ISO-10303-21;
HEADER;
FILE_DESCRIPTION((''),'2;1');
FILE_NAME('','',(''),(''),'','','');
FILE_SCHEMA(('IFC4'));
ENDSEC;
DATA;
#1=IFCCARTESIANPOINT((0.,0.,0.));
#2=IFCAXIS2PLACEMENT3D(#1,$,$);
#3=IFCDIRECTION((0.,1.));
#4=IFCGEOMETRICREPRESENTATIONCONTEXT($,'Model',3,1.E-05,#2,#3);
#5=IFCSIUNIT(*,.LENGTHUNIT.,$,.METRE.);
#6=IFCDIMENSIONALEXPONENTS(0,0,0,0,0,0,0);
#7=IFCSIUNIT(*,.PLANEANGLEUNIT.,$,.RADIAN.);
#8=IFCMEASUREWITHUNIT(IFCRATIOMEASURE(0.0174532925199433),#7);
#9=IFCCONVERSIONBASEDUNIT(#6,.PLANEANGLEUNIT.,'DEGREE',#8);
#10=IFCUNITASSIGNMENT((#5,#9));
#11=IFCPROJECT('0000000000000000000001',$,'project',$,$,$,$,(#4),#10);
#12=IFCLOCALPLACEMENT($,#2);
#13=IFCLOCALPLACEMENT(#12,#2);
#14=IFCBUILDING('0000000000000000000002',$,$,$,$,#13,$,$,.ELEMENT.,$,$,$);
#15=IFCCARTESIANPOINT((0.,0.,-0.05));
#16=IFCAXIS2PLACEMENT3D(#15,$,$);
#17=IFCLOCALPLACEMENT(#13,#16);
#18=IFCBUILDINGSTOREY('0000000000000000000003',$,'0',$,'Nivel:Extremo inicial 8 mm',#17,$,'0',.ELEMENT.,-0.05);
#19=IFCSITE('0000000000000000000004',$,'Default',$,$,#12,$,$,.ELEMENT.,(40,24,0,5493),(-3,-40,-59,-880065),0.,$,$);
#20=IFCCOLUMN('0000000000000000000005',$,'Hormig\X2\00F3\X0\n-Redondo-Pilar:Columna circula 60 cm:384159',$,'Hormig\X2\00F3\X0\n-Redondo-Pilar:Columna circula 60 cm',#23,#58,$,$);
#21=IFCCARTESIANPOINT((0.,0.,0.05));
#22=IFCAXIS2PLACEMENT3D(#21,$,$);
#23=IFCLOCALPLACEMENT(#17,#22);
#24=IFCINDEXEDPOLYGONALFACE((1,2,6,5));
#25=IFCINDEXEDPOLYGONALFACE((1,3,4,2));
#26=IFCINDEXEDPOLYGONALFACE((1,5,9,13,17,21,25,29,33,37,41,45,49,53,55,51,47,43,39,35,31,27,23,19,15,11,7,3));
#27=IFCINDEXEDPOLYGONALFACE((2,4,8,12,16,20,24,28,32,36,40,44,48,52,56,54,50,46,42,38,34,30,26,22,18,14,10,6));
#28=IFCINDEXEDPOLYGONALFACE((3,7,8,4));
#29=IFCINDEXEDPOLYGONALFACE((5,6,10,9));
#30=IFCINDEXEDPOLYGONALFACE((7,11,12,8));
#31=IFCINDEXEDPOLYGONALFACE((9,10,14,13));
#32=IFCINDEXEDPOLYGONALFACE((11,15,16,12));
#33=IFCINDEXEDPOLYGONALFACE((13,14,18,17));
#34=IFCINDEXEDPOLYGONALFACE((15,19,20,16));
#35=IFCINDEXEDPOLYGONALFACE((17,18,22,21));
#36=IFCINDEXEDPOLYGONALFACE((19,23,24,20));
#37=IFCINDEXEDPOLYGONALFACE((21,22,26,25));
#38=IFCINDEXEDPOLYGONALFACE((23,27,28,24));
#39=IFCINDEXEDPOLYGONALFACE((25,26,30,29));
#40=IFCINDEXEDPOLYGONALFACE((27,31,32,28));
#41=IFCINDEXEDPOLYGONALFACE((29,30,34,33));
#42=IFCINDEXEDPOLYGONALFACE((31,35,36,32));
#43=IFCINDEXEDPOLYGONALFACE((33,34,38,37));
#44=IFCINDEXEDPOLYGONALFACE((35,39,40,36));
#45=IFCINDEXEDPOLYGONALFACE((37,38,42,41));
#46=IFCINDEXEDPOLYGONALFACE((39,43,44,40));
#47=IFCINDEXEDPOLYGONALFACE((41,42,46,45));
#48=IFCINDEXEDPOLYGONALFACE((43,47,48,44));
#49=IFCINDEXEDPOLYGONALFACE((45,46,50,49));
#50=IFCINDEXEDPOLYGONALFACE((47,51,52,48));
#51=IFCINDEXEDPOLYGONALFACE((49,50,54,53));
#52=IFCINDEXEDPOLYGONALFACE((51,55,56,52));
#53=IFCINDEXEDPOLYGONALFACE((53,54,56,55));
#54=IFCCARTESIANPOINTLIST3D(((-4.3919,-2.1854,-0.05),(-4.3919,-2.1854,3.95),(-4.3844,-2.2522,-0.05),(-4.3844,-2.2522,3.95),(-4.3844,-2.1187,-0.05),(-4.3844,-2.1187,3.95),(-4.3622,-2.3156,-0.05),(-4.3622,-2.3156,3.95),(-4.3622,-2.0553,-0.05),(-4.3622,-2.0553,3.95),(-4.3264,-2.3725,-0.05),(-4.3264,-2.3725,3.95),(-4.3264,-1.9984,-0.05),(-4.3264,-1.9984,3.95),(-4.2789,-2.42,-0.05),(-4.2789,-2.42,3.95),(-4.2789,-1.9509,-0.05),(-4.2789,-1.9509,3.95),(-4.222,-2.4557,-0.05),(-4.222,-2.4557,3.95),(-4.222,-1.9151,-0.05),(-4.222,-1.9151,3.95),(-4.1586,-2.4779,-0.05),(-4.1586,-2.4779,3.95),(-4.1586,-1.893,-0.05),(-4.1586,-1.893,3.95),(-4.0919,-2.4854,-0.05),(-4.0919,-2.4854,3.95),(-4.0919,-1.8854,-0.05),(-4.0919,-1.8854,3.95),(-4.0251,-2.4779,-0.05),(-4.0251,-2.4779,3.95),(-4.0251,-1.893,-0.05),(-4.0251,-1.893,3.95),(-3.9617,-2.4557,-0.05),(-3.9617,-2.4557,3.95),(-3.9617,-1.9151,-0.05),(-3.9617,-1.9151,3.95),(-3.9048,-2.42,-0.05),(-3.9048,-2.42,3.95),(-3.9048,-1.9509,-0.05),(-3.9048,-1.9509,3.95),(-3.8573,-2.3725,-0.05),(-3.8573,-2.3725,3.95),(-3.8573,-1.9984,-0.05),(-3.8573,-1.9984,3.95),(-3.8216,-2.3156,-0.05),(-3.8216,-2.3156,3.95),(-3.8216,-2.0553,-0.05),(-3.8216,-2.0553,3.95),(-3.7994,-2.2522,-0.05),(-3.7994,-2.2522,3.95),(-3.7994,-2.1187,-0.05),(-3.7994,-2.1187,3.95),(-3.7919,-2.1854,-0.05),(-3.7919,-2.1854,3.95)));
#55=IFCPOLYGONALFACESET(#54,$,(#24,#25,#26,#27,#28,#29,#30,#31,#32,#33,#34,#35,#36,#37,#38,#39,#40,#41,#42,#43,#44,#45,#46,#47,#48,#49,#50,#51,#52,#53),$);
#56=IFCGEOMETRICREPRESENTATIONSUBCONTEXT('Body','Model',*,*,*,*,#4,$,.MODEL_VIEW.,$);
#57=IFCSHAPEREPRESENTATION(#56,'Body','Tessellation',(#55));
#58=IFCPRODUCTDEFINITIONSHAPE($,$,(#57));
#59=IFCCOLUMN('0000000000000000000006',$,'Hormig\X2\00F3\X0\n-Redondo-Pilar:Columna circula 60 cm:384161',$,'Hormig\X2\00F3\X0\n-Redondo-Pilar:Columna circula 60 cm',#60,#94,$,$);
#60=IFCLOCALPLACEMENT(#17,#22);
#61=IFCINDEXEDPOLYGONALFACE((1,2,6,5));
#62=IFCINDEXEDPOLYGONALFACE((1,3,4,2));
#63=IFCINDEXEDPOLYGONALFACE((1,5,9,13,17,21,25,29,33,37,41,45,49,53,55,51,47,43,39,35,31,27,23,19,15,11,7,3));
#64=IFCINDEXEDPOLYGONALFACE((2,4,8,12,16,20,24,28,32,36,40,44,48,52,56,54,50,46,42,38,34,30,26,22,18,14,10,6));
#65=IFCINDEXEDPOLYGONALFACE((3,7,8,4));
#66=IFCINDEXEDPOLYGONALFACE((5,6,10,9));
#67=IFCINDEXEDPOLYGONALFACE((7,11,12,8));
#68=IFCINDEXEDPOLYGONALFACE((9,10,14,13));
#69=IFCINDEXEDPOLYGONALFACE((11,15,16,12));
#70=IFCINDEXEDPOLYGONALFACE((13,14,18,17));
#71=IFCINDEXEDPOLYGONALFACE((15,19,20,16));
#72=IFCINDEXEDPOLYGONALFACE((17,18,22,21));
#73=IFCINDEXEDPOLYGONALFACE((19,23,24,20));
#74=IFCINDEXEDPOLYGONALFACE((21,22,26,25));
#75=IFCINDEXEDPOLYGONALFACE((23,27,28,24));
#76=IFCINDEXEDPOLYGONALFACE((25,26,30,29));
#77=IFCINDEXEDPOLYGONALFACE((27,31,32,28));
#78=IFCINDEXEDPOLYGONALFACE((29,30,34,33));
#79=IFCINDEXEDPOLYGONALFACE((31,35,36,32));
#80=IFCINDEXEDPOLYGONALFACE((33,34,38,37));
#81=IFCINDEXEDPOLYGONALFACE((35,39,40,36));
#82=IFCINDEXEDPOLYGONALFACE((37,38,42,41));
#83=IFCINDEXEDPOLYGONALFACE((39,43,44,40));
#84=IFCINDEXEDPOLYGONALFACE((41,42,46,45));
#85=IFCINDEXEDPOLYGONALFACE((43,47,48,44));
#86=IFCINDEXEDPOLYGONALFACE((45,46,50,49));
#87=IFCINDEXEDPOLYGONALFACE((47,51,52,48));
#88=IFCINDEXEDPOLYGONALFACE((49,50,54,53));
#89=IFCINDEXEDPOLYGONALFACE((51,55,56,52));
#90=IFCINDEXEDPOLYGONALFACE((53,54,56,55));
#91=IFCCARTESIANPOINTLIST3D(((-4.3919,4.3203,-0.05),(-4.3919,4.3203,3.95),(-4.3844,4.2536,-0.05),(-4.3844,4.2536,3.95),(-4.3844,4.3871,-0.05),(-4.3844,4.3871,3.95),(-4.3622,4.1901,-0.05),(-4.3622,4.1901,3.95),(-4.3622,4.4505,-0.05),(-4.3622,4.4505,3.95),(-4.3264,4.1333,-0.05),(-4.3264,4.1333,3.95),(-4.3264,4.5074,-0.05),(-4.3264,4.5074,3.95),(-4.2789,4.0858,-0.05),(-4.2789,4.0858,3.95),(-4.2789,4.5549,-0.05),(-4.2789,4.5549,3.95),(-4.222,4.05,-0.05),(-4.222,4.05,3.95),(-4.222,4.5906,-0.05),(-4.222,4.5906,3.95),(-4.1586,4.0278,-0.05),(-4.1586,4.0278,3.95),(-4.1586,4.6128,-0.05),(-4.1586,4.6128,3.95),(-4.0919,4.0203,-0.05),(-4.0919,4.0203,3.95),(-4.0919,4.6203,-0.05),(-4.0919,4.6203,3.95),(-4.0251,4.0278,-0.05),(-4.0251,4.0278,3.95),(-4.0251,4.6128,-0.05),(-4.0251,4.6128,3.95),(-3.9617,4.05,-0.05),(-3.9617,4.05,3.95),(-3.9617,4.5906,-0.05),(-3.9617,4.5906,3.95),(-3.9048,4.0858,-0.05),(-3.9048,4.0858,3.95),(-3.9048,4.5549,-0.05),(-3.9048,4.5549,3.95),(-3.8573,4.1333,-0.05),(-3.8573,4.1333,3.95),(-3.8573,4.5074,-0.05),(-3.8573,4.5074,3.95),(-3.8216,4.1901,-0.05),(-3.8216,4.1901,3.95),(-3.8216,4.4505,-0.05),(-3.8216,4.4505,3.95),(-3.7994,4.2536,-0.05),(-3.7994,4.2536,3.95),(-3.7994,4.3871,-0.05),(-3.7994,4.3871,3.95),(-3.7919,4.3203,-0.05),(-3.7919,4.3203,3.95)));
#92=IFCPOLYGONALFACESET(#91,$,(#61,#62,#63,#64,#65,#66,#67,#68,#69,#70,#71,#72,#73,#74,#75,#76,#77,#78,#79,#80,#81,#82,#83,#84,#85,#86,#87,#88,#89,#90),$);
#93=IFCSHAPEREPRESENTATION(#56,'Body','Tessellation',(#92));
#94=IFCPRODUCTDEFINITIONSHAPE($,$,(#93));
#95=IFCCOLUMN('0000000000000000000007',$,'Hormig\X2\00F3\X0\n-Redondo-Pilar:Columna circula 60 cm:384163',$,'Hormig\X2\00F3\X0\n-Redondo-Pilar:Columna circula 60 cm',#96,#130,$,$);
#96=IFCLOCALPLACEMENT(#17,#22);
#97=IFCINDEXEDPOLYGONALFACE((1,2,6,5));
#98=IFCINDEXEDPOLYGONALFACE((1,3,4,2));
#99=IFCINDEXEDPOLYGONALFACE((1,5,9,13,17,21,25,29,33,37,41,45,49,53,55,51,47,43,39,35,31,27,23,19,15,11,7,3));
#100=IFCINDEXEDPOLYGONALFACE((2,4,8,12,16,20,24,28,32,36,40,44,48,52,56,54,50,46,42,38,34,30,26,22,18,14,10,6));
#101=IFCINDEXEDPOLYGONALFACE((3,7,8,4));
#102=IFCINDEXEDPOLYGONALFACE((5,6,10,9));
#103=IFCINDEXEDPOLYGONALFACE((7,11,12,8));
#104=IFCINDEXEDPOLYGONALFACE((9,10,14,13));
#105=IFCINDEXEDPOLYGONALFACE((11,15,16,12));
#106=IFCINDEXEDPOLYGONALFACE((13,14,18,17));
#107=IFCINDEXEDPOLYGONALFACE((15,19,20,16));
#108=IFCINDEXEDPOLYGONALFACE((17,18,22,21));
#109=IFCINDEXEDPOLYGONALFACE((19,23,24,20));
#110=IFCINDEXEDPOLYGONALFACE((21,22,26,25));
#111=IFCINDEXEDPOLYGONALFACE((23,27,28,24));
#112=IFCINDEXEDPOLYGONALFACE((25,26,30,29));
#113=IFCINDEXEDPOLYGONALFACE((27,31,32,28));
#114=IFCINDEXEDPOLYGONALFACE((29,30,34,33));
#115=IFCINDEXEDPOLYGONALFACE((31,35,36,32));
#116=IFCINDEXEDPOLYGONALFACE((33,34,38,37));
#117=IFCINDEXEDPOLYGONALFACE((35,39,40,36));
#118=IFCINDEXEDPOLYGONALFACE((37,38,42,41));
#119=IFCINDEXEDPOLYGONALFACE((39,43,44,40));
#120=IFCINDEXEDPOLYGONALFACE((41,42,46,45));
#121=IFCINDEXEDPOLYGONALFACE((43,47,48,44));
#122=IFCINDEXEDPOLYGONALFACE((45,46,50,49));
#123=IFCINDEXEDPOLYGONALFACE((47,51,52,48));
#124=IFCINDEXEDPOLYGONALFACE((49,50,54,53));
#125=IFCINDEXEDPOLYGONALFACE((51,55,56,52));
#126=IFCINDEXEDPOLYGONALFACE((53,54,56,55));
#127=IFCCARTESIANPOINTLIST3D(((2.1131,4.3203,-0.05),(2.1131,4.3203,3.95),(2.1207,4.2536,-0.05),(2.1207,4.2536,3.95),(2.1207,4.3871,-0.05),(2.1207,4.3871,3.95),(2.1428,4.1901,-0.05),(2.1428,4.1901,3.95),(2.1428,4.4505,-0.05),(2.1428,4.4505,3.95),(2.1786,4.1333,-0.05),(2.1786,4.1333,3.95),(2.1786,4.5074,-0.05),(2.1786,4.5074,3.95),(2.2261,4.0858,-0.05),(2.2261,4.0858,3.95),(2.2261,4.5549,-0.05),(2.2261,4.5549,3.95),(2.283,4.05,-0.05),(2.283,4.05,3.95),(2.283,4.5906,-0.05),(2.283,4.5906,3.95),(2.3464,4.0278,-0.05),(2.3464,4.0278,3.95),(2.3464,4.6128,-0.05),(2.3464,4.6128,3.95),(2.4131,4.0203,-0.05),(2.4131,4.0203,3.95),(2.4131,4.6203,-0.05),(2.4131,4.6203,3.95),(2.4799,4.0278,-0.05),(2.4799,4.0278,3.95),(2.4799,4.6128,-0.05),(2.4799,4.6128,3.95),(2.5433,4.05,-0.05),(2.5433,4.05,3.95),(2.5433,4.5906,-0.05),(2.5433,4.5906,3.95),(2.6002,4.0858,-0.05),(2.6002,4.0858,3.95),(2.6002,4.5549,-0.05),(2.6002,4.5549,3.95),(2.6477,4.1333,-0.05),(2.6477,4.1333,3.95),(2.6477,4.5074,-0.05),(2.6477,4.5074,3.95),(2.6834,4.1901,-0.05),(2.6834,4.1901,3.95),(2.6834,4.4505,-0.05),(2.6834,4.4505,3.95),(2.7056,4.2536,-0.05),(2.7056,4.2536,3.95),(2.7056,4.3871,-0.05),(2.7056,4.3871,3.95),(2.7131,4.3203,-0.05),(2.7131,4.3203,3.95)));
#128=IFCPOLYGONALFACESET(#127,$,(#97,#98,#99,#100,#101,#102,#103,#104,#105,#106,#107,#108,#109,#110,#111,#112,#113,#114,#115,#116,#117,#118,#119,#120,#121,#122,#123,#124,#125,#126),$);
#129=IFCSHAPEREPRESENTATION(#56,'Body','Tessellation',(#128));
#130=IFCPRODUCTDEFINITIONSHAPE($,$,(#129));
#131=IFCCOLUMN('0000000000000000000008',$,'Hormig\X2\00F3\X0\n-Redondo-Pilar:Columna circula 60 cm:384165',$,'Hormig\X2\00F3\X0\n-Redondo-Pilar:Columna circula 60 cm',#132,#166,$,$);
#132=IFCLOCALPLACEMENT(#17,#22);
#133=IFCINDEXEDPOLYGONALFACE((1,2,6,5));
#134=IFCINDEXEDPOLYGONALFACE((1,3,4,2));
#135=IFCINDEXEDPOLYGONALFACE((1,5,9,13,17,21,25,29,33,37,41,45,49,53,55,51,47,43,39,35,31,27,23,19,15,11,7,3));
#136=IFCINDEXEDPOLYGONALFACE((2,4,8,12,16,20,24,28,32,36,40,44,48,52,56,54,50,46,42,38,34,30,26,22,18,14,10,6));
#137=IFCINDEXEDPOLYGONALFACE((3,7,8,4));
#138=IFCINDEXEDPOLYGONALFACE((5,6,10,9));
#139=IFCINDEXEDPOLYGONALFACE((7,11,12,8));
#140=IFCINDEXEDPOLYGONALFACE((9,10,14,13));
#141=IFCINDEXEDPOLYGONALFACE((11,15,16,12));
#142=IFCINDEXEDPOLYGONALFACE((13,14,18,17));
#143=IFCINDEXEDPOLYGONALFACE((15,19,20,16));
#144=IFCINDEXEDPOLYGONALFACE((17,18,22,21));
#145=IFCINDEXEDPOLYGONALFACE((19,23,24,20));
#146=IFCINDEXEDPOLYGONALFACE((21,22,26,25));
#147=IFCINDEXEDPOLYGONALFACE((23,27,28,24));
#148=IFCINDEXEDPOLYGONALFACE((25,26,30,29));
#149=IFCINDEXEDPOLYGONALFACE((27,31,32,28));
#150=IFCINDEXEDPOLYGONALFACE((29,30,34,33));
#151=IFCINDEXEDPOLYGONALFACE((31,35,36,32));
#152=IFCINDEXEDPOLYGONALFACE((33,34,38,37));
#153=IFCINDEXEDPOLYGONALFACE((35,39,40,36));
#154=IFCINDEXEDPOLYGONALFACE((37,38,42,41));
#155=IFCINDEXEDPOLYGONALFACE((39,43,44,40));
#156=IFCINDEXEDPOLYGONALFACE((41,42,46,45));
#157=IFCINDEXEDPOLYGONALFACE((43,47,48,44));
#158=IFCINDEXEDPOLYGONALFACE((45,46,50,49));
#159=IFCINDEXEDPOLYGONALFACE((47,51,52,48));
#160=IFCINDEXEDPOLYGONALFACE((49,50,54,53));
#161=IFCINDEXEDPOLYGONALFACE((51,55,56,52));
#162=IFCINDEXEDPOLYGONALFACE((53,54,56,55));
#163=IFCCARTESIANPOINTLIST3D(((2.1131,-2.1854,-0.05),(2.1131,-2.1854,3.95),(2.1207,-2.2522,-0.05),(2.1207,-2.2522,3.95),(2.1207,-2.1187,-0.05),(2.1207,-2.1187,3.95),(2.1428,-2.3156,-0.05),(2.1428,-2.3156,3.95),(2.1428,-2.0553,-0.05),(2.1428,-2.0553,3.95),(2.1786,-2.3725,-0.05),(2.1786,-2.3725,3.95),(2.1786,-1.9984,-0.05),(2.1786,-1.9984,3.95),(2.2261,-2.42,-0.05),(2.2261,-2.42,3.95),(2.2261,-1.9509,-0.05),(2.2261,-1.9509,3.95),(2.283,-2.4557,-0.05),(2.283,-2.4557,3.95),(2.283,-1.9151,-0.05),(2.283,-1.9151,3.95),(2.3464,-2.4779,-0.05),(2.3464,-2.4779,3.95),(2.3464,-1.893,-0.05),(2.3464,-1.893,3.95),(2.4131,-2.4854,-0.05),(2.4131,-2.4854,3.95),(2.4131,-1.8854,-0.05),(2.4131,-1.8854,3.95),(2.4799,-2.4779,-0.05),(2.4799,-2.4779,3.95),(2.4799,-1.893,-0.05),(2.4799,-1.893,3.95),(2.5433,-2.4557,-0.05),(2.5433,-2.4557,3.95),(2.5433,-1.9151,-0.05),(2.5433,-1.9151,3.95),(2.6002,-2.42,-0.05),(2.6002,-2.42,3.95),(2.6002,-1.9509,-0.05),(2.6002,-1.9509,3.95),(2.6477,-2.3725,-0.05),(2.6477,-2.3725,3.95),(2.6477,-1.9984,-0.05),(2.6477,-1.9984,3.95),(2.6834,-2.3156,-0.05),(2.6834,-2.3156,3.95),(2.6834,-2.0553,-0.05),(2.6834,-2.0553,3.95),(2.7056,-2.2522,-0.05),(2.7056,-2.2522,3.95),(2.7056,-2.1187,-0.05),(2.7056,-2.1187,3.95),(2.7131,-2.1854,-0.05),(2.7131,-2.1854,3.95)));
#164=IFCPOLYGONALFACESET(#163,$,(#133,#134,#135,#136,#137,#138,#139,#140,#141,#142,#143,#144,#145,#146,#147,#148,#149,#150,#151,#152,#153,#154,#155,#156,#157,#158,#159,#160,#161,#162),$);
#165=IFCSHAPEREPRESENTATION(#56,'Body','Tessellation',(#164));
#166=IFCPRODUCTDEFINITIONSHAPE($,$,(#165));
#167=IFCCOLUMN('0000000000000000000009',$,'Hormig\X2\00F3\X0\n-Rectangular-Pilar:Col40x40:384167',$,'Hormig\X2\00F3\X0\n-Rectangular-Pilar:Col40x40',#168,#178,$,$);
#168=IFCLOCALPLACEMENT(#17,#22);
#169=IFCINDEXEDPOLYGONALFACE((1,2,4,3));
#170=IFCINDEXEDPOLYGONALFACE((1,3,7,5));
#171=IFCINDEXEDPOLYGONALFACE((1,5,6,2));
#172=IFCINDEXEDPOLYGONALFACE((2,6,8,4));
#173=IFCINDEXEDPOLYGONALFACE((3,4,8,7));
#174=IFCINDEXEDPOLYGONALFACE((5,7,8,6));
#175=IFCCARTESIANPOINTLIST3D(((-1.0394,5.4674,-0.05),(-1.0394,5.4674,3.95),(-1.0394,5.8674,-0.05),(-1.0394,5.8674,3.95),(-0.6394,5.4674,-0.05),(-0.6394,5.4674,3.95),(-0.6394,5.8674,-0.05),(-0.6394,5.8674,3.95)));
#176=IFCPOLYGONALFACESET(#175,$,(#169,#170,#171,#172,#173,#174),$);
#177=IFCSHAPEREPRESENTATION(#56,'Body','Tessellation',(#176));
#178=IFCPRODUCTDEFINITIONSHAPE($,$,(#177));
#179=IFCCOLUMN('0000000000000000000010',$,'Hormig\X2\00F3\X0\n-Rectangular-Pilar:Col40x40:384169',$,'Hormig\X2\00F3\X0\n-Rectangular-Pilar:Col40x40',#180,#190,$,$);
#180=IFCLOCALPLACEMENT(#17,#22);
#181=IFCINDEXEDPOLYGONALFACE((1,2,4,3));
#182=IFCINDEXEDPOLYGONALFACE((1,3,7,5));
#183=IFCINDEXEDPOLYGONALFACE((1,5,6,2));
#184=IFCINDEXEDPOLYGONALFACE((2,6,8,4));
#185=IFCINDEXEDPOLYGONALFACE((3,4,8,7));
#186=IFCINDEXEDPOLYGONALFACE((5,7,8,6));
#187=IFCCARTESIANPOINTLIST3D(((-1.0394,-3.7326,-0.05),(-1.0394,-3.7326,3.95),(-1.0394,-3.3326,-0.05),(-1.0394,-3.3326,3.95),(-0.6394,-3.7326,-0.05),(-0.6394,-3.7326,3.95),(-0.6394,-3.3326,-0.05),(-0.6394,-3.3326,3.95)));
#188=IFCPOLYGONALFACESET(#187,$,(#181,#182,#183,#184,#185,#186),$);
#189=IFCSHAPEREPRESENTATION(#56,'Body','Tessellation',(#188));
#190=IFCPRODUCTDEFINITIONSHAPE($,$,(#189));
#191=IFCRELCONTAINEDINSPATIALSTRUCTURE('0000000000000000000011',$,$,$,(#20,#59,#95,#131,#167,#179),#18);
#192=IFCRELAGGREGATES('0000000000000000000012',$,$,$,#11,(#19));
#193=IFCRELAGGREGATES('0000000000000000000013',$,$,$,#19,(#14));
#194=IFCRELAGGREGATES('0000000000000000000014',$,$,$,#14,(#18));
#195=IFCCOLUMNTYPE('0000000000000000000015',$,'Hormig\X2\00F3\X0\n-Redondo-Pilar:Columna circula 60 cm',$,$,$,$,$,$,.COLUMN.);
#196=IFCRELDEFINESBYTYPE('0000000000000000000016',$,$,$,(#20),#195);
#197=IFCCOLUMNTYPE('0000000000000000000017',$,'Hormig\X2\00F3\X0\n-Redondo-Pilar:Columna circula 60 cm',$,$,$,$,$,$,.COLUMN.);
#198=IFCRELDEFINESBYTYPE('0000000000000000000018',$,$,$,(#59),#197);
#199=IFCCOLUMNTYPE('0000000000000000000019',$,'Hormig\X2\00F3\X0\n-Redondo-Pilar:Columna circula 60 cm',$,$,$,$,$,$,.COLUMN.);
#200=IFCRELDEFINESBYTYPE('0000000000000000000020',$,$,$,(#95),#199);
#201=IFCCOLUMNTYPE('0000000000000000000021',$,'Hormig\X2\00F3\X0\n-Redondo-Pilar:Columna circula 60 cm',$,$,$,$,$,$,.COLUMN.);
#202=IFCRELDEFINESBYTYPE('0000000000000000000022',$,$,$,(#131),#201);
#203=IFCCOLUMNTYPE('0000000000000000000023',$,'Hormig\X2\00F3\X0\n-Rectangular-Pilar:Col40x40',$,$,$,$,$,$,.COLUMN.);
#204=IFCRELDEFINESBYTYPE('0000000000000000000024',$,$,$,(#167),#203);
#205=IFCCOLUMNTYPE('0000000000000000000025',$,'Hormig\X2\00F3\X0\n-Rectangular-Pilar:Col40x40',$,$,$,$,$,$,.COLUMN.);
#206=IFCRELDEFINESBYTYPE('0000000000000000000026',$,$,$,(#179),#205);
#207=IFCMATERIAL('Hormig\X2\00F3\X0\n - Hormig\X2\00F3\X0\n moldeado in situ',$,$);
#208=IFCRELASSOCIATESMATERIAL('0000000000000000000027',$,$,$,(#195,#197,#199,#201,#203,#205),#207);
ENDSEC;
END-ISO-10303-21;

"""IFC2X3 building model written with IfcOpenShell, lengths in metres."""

from ifc_helpers import new_model, entity, si_unit, converted_unit, direction, frame, frame_2d, origin, origin_2d_with_axis, place, context, subcontext, project, spatial, rectangle, circle, extrude, source, transform, mapped, material, type_object, type_shapes, element, save


model = new_model("IFC2X3")

# Units and contexts
model_context = context("Model", 3, precision=1e-05, world=origin(), true_north=direction((0.0, 1.0)))
body_context = subcontext(model_context, "Body", "Model", "MODEL_VIEW")
ifc_project = project(units=[si_unit("LENGTHUNIT", "METRE"), converted_unit("PLANEANGLEUNIT", "DEGREE", entity("IfcRatioMeasure", 0.0174532925199433), si_unit("PLANEANGLEUNIT", "RADIAN"), dimensions=[0, 0, 0, 0, 0, 0, 0])], contexts=[model_context])

# Site, building, storey
site_placement = place(None, origin())
site = spatial("IfcSite", under=ifc_project, at=site_placement, Name="Default", CompositionType="ELEMENT", RefLatitude=(40, 24, 0, 5493), RefLongitude=(-3, -40, -59, -880065), RefElevation=0.0)
building_placement = place(site_placement, origin())
building = spatial("IfcBuilding", under=site, at=building_placement, CompositionType="ELEMENT")
storey_placement = place(building_placement, frame((0.0, 0.0, -0.05)))
storey = spatial("IfcBuildingStorey", under=building, at=storey_placement, Name="0", ObjectType="Nivel:Extremo inicial 8 mm", LongName="0", CompositionType="ELEMENT", Elevation=-0.05)

# Columns
ifc_material_1 = material(Name="Hormigón - Hormigón moldeado in situ")
column_type_1 = type_object("IfcColumnType", Name="Hormigón-Redondo-Pilar:Columna circula 60 cm", PredefinedType="COLUMN", material=ifc_material_1)
shared_shape_1 = source(origin(), body_context, "Body", "SweptSolid", [
    extrude(circle(Radius=0.3, at=frame_2d((0.0, 0.0), x_axis=(1.0, 0.0))), frame((-4.0919, -2.1854, -0.05)), (0.0, 0.0, 1.0), 4.0),
])
type_shapes(column_type_1, [shared_shape_1])
column_1_placement = place(storey_placement, frame((0.0, 0.0, 0.05)))
element("IfcColumn", 1, at=column_1_placement, inside=storey, type_object=column_type_1, Name="Hormigón-Redondo-Pilar:Columna circula 60 cm:384159", ObjectType="Hormigón-Redondo-Pilar:Columna circula 60 cm", context=body_context, shape_type="MappedRepresentation", body=[
    mapped(shared_shape_1, transform((0.0, 0.0, 0.0), scale=1.0)),
])
column_type_2 = type_object("IfcColumnType", Name="Hormigón-Redondo-Pilar:Columna circula 60 cm", PredefinedType="COLUMN", material=ifc_material_1)
shared_shape_2 = source(origin(), body_context, "Body", "SweptSolid", [
    extrude(circle(Radius=0.3, at=frame_2d((0.0, 0.0), x_axis=(1.0, 0.0))), frame((-4.0919, 4.3203, -0.05)), (0.0, 0.0, 1.0), 4.0),
])
type_shapes(column_type_2, [shared_shape_2])
column_2_placement = place(storey_placement, frame((0.0, 0.0, 0.05)))
element("IfcColumn", 2, at=column_2_placement, inside=storey, type_object=column_type_2, Name="Hormigón-Redondo-Pilar:Columna circula 60 cm:384161", ObjectType="Hormigón-Redondo-Pilar:Columna circula 60 cm", context=body_context, shape_type="MappedRepresentation", body=[
    mapped(shared_shape_2, transform((0.0, 0.0, 0.0), scale=1.0)),
])
column_type_3 = type_object("IfcColumnType", Name="Hormigón-Redondo-Pilar:Columna circula 60 cm", PredefinedType="COLUMN", material=ifc_material_1)
shared_shape_3 = source(origin(), body_context, "Body", "SweptSolid", [
    extrude(circle(Radius=0.3, at=frame_2d((0.0, 0.0), x_axis=(1.0, 0.0))), frame((2.4131, 4.3203, -0.05)), (0.0, 0.0, 1.0), 4.0),
])
type_shapes(column_type_3, [shared_shape_3])
column_3_placement = place(storey_placement, frame((0.0, 0.0, 0.05)))
element("IfcColumn", 3, at=column_3_placement, inside=storey, type_object=column_type_3, Name="Hormigón-Redondo-Pilar:Columna circula 60 cm:384163", ObjectType="Hormigón-Redondo-Pilar:Columna circula 60 cm", context=body_context, shape_type="MappedRepresentation", body=[
    mapped(shared_shape_3, transform((0.0, 0.0, 0.0), scale=1.0)),
])
column_type_4 = type_object("IfcColumnType", Name="Hormigón-Redondo-Pilar:Columna circula 60 cm", PredefinedType="COLUMN", material=ifc_material_1)
shared_shape_4 = source(origin(), body_context, "Body", "SweptSolid", [
    extrude(circle(Radius=0.3, at=frame_2d((0.0, 0.0), x_axis=(1.0, 0.0))), frame((2.4131, -2.1854, -0.05)), (0.0, 0.0, 1.0), 4.0),
])
type_shapes(column_type_4, [shared_shape_4])
column_4_placement = place(storey_placement, frame((0.0, 0.0, 0.05)))
element("IfcColumn", 4, at=column_4_placement, inside=storey, type_object=column_type_4, Name="Hormigón-Redondo-Pilar:Columna circula 60 cm:384165", ObjectType="Hormigón-Redondo-Pilar:Columna circula 60 cm", context=body_context, shape_type="MappedRepresentation", body=[
    mapped(shared_shape_4, transform((0.0, 0.0, 0.0), scale=1.0)),
])
column_type_5 = type_object("IfcColumnType", Name="Hormigón-Rectangular-Pilar:Col40x40", PredefinedType="COLUMN", material=ifc_material_1)
shared_shape_5 = source(origin(), body_context, "Body", "SweptSolid", [
    extrude(rectangle(XDim=0.4, YDim=0.4, at=origin_2d_with_axis()), frame((-0.8394, 5.6674, -0.05), z_axis=(0.0, 0.0, 1.0), x_axis=(0.0, -1.0, 0.0)), (0.0, 0.0, 1.0), 4.0),
])
type_shapes(column_type_5, [shared_shape_5])
column_5_placement = place(storey_placement, frame((0.0, 0.0, 0.05)))
element("IfcColumn", 5, at=column_5_placement, inside=storey, type_object=column_type_5, Name="Hormigón-Rectangular-Pilar:Col40x40:384167", ObjectType="Hormigón-Rectangular-Pilar:Col40x40", context=body_context, shape_type="MappedRepresentation", body=[
    mapped(shared_shape_5, transform((0.0, 0.0, 0.0), scale=1.0)),
])
column_type_6 = type_object("IfcColumnType", Name="Hormigón-Rectangular-Pilar:Col40x40", PredefinedType="COLUMN", material=ifc_material_1)
shared_shape_6 = source(origin(), body_context, "Body", "SweptSolid", [
    extrude(rectangle(XDim=0.4, YDim=0.4, at=origin_2d_with_axis()), frame((-0.8394, -3.5326, -0.05), z_axis=(0.0, 0.0, 1.0), x_axis=(0.0, -1.0, 0.0)), (0.0, 0.0, 1.0), 4.0),
])
type_shapes(column_type_6, [shared_shape_6])
column_6_placement = place(storey_placement, frame((0.0, 0.0, 0.05)))
element("IfcColumn", 6, at=column_6_placement, inside=storey, type_object=column_type_6, Name="Hormigón-Rectangular-Pilar:Col40x40:384169", ObjectType="Hormigón-Rectangular-Pilar:Col40x40", context=body_context, shape_type="MappedRepresentation", body=[
    mapped(shared_shape_6, transform((0.0, 0.0, 0.0), scale=1.0)),
])

save(model, "model.ifc")
